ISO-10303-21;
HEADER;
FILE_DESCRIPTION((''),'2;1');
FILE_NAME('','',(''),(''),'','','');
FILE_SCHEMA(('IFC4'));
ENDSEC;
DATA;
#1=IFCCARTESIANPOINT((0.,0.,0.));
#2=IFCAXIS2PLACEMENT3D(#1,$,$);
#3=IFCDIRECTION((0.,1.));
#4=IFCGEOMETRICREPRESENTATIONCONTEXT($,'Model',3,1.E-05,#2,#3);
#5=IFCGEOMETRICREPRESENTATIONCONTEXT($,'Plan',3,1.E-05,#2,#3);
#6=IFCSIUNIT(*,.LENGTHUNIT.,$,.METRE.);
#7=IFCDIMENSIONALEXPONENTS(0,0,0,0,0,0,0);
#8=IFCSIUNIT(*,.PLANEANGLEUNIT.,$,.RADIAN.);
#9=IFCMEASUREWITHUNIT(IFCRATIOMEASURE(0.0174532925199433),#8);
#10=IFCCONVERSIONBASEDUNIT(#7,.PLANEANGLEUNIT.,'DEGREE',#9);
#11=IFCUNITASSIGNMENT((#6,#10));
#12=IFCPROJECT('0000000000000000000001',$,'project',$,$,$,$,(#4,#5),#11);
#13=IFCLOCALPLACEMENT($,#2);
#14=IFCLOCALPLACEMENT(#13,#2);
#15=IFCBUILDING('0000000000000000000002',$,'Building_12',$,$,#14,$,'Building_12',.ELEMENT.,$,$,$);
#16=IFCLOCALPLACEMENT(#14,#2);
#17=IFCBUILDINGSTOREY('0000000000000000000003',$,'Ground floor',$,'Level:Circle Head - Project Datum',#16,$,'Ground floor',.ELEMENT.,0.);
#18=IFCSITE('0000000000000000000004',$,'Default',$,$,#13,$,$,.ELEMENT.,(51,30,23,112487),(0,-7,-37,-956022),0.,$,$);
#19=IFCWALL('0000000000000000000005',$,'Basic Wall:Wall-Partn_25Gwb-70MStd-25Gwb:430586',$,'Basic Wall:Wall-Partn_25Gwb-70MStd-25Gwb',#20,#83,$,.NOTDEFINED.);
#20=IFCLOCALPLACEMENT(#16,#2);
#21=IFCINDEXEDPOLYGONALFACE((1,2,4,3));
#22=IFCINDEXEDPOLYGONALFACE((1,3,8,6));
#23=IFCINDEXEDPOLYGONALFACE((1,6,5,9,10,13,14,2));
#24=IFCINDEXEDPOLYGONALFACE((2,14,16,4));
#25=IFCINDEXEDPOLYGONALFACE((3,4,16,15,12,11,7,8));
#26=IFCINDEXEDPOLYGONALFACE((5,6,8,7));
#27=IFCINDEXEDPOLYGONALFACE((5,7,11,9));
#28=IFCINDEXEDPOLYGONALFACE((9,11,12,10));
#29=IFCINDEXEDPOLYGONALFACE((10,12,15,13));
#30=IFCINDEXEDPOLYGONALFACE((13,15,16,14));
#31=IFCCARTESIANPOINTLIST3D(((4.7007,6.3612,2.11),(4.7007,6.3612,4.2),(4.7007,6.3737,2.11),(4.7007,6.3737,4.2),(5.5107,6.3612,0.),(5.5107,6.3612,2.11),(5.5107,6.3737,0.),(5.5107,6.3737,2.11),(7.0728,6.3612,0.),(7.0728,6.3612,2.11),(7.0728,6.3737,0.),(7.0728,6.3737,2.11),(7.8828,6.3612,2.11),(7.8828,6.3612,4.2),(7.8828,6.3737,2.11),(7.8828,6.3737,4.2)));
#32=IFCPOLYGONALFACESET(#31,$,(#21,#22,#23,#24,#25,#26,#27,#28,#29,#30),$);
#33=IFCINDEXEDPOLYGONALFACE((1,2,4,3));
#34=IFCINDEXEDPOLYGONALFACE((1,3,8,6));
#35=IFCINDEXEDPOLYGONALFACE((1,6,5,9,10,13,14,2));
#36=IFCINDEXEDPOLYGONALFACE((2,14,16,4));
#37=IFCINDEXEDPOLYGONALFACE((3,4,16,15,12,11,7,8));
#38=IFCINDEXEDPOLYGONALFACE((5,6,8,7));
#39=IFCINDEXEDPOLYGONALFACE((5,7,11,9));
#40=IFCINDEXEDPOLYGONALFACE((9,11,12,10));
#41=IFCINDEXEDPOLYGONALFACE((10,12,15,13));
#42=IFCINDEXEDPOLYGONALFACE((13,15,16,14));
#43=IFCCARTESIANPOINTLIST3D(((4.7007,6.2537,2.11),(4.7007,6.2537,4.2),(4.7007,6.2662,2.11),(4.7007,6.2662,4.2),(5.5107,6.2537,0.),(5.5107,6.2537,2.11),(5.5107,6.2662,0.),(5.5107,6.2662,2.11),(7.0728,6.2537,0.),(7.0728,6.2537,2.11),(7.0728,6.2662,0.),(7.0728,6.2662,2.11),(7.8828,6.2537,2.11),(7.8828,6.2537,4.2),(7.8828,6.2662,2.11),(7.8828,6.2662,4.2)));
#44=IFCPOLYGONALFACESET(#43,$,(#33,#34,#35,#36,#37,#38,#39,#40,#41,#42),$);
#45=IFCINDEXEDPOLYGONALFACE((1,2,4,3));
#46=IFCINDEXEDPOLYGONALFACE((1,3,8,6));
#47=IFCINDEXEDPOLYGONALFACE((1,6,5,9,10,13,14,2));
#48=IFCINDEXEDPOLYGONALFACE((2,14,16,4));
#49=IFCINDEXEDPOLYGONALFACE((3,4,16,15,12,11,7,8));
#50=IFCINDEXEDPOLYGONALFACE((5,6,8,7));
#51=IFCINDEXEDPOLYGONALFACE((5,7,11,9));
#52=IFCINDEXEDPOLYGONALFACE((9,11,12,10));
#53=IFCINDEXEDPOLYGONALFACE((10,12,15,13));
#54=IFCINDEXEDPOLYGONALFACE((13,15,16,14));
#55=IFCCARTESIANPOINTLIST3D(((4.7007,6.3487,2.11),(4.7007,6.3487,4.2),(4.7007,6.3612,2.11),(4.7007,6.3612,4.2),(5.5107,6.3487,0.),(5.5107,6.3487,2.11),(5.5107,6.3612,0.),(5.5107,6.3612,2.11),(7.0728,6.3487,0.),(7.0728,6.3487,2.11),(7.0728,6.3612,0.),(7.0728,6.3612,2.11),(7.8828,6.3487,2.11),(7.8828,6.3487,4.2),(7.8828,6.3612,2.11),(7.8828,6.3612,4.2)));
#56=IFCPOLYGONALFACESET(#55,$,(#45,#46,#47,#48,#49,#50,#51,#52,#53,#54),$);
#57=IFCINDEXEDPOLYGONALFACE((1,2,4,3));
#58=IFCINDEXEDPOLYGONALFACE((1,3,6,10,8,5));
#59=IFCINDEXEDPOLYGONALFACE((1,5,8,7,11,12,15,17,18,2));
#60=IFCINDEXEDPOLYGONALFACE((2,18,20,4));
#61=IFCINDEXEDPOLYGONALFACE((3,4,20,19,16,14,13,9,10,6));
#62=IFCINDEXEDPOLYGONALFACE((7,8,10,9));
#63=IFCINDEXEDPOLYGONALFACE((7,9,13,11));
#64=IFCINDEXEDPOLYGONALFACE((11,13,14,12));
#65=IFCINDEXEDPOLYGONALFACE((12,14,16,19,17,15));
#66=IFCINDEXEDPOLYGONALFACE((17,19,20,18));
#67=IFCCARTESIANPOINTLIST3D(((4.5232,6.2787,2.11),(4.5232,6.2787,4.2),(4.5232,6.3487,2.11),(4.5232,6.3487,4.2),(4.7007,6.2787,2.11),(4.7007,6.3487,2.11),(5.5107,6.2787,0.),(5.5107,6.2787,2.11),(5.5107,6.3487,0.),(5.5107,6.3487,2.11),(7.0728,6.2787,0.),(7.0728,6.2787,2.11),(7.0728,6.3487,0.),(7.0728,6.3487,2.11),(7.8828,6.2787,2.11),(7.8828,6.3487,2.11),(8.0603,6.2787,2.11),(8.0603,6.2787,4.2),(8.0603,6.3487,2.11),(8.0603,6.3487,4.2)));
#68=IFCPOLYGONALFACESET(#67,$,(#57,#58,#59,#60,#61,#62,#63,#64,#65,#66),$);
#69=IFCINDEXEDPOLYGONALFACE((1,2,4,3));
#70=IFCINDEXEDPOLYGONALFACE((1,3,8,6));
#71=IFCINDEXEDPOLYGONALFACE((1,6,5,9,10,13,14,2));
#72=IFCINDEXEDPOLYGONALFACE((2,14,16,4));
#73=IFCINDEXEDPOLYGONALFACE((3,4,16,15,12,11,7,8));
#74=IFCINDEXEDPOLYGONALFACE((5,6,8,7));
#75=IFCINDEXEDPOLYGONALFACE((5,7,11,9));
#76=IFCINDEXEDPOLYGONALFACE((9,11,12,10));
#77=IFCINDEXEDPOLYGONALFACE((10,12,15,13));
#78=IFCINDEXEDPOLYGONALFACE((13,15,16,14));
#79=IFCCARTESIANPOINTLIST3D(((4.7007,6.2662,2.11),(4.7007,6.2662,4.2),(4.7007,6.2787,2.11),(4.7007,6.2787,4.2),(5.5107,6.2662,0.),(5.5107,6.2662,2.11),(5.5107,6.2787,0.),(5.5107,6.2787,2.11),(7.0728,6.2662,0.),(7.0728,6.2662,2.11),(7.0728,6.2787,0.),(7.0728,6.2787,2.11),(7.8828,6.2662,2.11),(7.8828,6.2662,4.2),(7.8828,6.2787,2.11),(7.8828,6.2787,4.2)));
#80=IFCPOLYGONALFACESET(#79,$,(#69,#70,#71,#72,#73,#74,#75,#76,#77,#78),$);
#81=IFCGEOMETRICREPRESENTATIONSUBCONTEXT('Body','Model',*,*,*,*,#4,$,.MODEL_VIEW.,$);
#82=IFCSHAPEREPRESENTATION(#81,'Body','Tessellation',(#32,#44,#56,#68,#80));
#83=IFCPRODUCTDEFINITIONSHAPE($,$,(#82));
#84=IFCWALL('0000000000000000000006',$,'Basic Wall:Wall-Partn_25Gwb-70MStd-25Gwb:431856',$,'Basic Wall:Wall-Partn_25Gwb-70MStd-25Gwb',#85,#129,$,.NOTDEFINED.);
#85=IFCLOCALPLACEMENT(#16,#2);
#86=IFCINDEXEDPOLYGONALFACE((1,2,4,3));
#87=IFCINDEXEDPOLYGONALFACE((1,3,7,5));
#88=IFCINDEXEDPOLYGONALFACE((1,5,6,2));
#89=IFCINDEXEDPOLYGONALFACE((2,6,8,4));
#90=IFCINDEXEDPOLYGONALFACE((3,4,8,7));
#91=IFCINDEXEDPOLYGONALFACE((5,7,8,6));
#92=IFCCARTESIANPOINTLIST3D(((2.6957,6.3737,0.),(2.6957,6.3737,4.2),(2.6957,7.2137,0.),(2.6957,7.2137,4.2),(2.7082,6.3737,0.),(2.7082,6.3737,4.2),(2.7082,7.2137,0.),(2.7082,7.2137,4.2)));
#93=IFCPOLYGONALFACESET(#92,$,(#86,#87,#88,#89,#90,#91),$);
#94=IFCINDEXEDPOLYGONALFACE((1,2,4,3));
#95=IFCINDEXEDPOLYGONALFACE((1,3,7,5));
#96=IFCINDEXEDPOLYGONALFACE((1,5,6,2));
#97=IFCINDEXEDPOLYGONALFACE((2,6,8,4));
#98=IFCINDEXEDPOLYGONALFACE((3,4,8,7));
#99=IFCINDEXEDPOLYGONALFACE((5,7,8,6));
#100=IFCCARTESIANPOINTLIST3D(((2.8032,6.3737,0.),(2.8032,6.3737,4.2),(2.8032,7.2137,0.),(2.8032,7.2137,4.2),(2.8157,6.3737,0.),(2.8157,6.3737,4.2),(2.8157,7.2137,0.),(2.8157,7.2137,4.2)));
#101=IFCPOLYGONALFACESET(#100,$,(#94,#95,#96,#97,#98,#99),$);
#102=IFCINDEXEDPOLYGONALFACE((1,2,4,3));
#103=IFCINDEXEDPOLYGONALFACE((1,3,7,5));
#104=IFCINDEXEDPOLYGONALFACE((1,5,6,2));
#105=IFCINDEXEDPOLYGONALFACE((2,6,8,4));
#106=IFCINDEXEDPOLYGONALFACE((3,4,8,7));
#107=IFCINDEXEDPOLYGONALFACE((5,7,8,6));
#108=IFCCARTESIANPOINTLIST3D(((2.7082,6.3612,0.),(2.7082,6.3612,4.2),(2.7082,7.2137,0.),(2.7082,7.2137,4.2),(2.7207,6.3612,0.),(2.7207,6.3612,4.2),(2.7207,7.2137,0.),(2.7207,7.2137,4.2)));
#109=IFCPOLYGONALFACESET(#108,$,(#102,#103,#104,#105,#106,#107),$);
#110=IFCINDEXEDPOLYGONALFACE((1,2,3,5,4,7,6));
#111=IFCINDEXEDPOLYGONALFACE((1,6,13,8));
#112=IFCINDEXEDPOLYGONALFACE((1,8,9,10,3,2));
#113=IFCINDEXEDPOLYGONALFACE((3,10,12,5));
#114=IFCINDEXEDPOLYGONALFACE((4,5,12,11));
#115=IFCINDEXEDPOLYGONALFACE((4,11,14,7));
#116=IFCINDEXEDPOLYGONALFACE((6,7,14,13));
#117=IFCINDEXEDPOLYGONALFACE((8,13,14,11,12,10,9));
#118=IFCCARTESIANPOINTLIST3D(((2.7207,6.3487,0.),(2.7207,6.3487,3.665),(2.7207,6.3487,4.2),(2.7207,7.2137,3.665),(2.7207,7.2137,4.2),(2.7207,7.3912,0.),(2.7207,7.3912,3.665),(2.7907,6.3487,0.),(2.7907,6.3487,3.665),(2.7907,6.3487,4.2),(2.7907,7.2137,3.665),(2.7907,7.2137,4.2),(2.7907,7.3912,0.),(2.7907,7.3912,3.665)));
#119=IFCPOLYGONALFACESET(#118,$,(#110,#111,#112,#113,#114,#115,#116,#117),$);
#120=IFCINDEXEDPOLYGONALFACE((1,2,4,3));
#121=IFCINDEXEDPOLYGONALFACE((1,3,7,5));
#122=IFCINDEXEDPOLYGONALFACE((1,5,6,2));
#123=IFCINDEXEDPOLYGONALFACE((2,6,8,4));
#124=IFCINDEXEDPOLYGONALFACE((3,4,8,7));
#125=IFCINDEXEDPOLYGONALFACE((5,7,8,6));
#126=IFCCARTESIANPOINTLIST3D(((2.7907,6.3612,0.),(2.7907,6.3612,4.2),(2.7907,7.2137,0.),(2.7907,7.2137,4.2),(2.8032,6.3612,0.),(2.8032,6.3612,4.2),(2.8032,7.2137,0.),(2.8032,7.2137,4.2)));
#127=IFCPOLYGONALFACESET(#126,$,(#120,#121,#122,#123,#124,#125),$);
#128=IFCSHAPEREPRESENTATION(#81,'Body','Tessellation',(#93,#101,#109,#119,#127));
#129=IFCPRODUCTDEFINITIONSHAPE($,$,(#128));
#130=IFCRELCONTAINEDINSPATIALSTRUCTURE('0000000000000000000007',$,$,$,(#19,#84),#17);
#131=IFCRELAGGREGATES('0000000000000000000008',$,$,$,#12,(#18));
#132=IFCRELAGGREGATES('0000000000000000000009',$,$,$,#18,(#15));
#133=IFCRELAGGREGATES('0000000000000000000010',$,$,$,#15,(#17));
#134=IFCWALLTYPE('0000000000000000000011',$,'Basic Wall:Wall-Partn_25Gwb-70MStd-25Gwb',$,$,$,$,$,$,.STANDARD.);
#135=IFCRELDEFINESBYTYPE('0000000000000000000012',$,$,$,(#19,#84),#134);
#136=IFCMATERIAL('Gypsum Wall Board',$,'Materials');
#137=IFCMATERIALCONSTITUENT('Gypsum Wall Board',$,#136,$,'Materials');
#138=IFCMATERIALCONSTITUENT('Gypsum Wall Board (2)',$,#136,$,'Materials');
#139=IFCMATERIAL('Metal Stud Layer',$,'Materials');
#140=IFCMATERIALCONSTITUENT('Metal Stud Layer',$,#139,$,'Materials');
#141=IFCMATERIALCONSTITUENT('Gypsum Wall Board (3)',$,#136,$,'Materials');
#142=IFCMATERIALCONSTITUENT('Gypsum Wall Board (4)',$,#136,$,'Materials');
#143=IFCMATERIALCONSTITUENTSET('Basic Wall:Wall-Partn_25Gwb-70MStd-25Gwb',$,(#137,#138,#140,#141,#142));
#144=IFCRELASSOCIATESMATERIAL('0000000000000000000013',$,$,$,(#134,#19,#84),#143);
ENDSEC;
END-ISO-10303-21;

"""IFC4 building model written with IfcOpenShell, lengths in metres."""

from ifc_helpers import new_model, entity, si_unit, converted_unit, direction, frame, origin, place, context, subcontext, project, spatial, indexed_curve, outline, extrude, material, constituent, constituent_set, type_object, element, save


model = new_model("IFC4")

# Units and contexts
model_context = context("Model", 3, precision=1e-05, world=origin(), true_north=direction((0.0, 1.0)))
plan_context = context("Plan", 3, precision=1e-05, world=origin(), true_north=direction((0.0, 1.0)))
body_context = subcontext(model_context, "Body", "Model", "MODEL_VIEW")
ifc_project = project(units=[si_unit("LENGTHUNIT", "METRE"), converted_unit("PLANEANGLEUNIT", "DEGREE", entity("IfcRatioMeasure", 0.0174532925199433), si_unit("PLANEANGLEUNIT", "RADIAN"), dimensions=[0, 0, 0, 0, 0, 0, 0])], contexts=[model_context, plan_context])

# Site, building, storey
site_placement = place(None, origin())
site = spatial("IfcSite", under=ifc_project, at=site_placement, Name="Default", CompositionType="ELEMENT", RefLatitude=(51, 30, 23, 112487), RefLongitude=(0, -7, -37, -956022), RefElevation=0.0)
building_placement = place(site_placement, origin())
building = spatial("IfcBuilding", under=site, at=building_placement, Name="Building_12", LongName="Building_12", CompositionType="ELEMENT")
storey_placement = place(building_placement, origin())
storey = spatial("IfcBuildingStorey", under=building, at=storey_placement, Name="Ground floor", ObjectType="Level:Circle Head - Project Datum", LongName="Ground floor", CompositionType="ELEMENT", Elevation=0.0)

# Shared definitions
ifc_material_1 = material(Name="Gypsum Wall Board", Category="Materials")
ifc_constituent_1 = constituent(ifc_material_1, Name="Gypsum Wall Board", Category="Materials")
ifc_constituent_2 = constituent(ifc_material_1, Name="Gypsum Wall Board (2)", Category="Materials")
ifc_material_2 = material(Name="Metal Stud Layer", Category="Materials")
ifc_constituent_3 = constituent(ifc_material_2, Name="Metal Stud Layer", Category="Materials")
ifc_constituent_4 = constituent(ifc_material_1, Name="Gypsum Wall Board (3)", Category="Materials")
ifc_constituent_5 = constituent(ifc_material_1, Name="Gypsum Wall Board (4)", Category="Materials")
ifc_constituent_set_1 = constituent_set(constituents=[ifc_constituent_1, ifc_constituent_2, ifc_constituent_3, ifc_constituent_4, ifc_constituent_5], Name="Basic Wall:Wall-Partn_25Gwb-70MStd-25Gwb")
wall_type_1 = type_object("IfcWallType", Name="Basic Wall:Wall-Partn_25Gwb-70MStd-25Gwb", PredefinedType="STANDARD", material=ifc_constituent_set_1)

# Wall, openings
wall_1_placement = place(storey_placement, frame((7.8828, 6.3137, 0.0), z_axis=(0.0, 0.0, 1.0), x_axis=(-1.0, 0.0, 0.0)))
wall_1 = element("IfcWall", 1, at=wall_1_placement, inside=storey, type_object=wall_type_1, material=ifc_constituent_set_1, Name="Basic Wall:Wall-Partn_25Gwb-70MStd-25Gwb:430586", ObjectType="Basic Wall:Wall-Partn_25Gwb-70MStd-25Gwb", PredefinedType="NOTDEFINED", context=body_context, shape_type="SweptSolid", body=[
    extrude(outline(indexed_curve([(-2.105, 0.7811), (-2.105, -0.7811), (0.005, -0.7811), (0.005, -1.5911), (2.095, -1.5911), (2.095, 1.5911), (0.005, 1.5911), (0.005, 0.7811), (-2.105, 0.7811)], self_intersect=False)), frame((1.5911, -0.0475, 2.105), z_axis=(0.0, 1.0, 0.0), x_axis=(0.0, 0.0, 1.0)), (0.0, 0.0, -1.0), 0.0125),
    extrude(outline(indexed_curve([(-2.095, -1.5911), (-0.005, -1.5911), (-0.005, -0.7811), (2.105, -0.7811), (2.105, 0.7811), (-0.005, 0.7811), (-0.005, 1.5911), (-2.095, 1.5911), (-2.095, -1.5911)], self_intersect=False)), frame((1.5911, 0.06, 2.105), z_axis=(0.0, -1.0, 0.0), x_axis=(0.0, 0.0, -1.0)), (0.0, 0.0, 1.0), 0.0125),
    extrude(outline(indexed_curve([(-2.105, 0.7811), (-2.105, -0.7811), (0.005, -0.7811), (0.005, -1.5911), (2.095, -1.5911), (2.095, 1.5911), (0.005, 1.5911), (0.005, 0.7811), (-2.105, 0.7811)], self_intersect=False)), frame((1.5911, -0.035, 2.105), z_axis=(0.0, 1.0, 0.0), x_axis=(0.0, 0.0, 1.0)), (0.0, 0.0, -1.0), 0.0125),
    extrude(outline(indexed_curve([(-2.105, 0.7811), (-2.105, -0.7811), (0.005, -0.7811), (0.005, -1.7686), (2.095, -1.7686), (2.095, 1.7686), (0.005, 1.7686), (0.005, 0.7811), (-2.105, 0.7811)], self_intersect=False)), frame((1.5911, 0.035, 2.105), z_axis=(0.0, 1.0, 0.0), x_axis=(0.0, 0.0, 1.0)), (0.0, 0.0, -1.0), 0.07),
    extrude(outline(indexed_curve([(-2.105, 0.7811), (-2.105, -0.7811), (0.005, -0.7811), (0.005, -1.5911), (2.095, -1.5911), (2.095, 1.5911), (0.005, 1.5911), (0.005, 0.7811), (-2.105, 0.7811)], self_intersect=False)), frame((1.5911, 0.0475, 2.105), z_axis=(0.0, 1.0, 0.0), x_axis=(0.0, 0.0, 1.0)), (0.0, 0.0, -1.0), 0.0125),
])
opening_1_placement = place(wall_1_placement, frame((3.1821, 0.06, 0.0)))
element("IfcOpeningElement", 2, at=opening_1_placement, cuts=wall_1, PredefinedType="OPENING", context=body_context, shape_type="SweptSolid", body=[
    extrude(outline(indexed_curve([(0.0, 0.81), (0.0, 0.0), (2.11, 0.0), (2.11, 0.81), (0.0, 0.81)], self_intersect=False)), frame((0.0, 0.0, 0.0), z_axis=(0.0, -1.0, 0.0), x_axis=(0.0, 0.0, 1.0)), (0.0, 0.0, 1.0), 0.12),
])
opening_2_placement = place(wall_1_placement, frame((0.81, 0.06, 0.0)))
element("IfcOpeningElement", 3, at=opening_2_placement, cuts=wall_1, PredefinedType="OPENING", context=body_context, shape_type="SweptSolid", body=[
    extrude(outline(indexed_curve([(0.0, 0.81), (0.0, 0.0), (2.11, 0.0), (2.11, 0.81), (0.0, 0.81)], self_intersect=False)), frame((0.0, 0.0, 0.0), z_axis=(0.0, -1.0, 0.0), x_axis=(0.0, 0.0, 1.0)), (0.0, 0.0, 1.0), 0.12),
])

# Wall
wall_2_placement = place(storey_placement, frame((2.7557, 7.2137, 0.0), z_axis=(0.0, 0.0, 1.0), x_axis=(0.0, -1.0, 0.0)))
element("IfcWall", 4, at=wall_2_placement, inside=storey, type_object=wall_type_1, material=ifc_constituent_set_1, Name="Basic Wall:Wall-Partn_25Gwb-70MStd-25Gwb:431856", ObjectType="Basic Wall:Wall-Partn_25Gwb-70MStd-25Gwb", PredefinedType="NOTDEFINED", context=body_context, shape_type="SweptSolid", body=[
    extrude(outline(indexed_curve([(-0.0063, -0.42), (0.0062, -0.42), (0.0063, 0.42), (-0.0062, 0.42), (-0.0063, -0.42)], self_intersect=False)), frame((0.42, -0.0537, 0.0), z_axis=(0.0, 0.0, 1.0), x_axis=(0.0, 1.0, 0.0)), (0.0, 0.0, 1.0), 4.2),
    extrude(outline(indexed_curve([(-0.0063, -0.42), (0.0062, -0.42), (0.0063, 0.42), (-0.0062, 0.42), (-0.0063, -0.42)], self_intersect=False)), frame((0.42, 0.0538, 0.0), z_axis=(0.0, 0.0, 1.0), x_axis=(0.0, -1.0, 0.0)), (0.0, 0.0, 1.0), 4.2),
    extrude(outline(indexed_curve([(-0.0063, -0.4262), (0.0062, -0.4262), (0.0063, 0.4262), (-0.0062, 0.4262), (-0.0063, -0.4262)], self_intersect=False)), frame((0.4262, -0.0413, 0.0), z_axis=(0.0, 0.0, 1.0), x_axis=(0.0, -1.0, 0.0)), (0.0, 0.0, 1.0), 4.2),
    extrude(outline(indexed_curve([(-2.7707, -0.4975), (0.8943, -0.4975), (0.8943, -0.32), (1.4293, -0.32), (1.4293, 0.545), (0.8943, 0.545), (-2.7707, 0.545), (-2.7707, -0.4975)], self_intersect=False)), frame((0.32, -0.035, 2.7707), z_axis=(0.0, 1.0, 0.0), x_axis=(0.0, 0.0, 1.0)), (0.0, 0.0, 1.0), 0.07),
    extrude(outline(indexed_curve([(-0.0063, -0.4262), (0.0062, -0.4262), (0.0063, 0.4262), (-0.0062, 0.4262), (-0.0063, -0.4262)], self_intersect=False)), frame((0.4262, 0.0413, 0.0), z_axis=(0.0, 0.0, 1.0), x_axis=(0.0, -1.0, 0.0)), (0.0, 0.0, 1.0), 4.2),
])

save(model, "model.ifc")
